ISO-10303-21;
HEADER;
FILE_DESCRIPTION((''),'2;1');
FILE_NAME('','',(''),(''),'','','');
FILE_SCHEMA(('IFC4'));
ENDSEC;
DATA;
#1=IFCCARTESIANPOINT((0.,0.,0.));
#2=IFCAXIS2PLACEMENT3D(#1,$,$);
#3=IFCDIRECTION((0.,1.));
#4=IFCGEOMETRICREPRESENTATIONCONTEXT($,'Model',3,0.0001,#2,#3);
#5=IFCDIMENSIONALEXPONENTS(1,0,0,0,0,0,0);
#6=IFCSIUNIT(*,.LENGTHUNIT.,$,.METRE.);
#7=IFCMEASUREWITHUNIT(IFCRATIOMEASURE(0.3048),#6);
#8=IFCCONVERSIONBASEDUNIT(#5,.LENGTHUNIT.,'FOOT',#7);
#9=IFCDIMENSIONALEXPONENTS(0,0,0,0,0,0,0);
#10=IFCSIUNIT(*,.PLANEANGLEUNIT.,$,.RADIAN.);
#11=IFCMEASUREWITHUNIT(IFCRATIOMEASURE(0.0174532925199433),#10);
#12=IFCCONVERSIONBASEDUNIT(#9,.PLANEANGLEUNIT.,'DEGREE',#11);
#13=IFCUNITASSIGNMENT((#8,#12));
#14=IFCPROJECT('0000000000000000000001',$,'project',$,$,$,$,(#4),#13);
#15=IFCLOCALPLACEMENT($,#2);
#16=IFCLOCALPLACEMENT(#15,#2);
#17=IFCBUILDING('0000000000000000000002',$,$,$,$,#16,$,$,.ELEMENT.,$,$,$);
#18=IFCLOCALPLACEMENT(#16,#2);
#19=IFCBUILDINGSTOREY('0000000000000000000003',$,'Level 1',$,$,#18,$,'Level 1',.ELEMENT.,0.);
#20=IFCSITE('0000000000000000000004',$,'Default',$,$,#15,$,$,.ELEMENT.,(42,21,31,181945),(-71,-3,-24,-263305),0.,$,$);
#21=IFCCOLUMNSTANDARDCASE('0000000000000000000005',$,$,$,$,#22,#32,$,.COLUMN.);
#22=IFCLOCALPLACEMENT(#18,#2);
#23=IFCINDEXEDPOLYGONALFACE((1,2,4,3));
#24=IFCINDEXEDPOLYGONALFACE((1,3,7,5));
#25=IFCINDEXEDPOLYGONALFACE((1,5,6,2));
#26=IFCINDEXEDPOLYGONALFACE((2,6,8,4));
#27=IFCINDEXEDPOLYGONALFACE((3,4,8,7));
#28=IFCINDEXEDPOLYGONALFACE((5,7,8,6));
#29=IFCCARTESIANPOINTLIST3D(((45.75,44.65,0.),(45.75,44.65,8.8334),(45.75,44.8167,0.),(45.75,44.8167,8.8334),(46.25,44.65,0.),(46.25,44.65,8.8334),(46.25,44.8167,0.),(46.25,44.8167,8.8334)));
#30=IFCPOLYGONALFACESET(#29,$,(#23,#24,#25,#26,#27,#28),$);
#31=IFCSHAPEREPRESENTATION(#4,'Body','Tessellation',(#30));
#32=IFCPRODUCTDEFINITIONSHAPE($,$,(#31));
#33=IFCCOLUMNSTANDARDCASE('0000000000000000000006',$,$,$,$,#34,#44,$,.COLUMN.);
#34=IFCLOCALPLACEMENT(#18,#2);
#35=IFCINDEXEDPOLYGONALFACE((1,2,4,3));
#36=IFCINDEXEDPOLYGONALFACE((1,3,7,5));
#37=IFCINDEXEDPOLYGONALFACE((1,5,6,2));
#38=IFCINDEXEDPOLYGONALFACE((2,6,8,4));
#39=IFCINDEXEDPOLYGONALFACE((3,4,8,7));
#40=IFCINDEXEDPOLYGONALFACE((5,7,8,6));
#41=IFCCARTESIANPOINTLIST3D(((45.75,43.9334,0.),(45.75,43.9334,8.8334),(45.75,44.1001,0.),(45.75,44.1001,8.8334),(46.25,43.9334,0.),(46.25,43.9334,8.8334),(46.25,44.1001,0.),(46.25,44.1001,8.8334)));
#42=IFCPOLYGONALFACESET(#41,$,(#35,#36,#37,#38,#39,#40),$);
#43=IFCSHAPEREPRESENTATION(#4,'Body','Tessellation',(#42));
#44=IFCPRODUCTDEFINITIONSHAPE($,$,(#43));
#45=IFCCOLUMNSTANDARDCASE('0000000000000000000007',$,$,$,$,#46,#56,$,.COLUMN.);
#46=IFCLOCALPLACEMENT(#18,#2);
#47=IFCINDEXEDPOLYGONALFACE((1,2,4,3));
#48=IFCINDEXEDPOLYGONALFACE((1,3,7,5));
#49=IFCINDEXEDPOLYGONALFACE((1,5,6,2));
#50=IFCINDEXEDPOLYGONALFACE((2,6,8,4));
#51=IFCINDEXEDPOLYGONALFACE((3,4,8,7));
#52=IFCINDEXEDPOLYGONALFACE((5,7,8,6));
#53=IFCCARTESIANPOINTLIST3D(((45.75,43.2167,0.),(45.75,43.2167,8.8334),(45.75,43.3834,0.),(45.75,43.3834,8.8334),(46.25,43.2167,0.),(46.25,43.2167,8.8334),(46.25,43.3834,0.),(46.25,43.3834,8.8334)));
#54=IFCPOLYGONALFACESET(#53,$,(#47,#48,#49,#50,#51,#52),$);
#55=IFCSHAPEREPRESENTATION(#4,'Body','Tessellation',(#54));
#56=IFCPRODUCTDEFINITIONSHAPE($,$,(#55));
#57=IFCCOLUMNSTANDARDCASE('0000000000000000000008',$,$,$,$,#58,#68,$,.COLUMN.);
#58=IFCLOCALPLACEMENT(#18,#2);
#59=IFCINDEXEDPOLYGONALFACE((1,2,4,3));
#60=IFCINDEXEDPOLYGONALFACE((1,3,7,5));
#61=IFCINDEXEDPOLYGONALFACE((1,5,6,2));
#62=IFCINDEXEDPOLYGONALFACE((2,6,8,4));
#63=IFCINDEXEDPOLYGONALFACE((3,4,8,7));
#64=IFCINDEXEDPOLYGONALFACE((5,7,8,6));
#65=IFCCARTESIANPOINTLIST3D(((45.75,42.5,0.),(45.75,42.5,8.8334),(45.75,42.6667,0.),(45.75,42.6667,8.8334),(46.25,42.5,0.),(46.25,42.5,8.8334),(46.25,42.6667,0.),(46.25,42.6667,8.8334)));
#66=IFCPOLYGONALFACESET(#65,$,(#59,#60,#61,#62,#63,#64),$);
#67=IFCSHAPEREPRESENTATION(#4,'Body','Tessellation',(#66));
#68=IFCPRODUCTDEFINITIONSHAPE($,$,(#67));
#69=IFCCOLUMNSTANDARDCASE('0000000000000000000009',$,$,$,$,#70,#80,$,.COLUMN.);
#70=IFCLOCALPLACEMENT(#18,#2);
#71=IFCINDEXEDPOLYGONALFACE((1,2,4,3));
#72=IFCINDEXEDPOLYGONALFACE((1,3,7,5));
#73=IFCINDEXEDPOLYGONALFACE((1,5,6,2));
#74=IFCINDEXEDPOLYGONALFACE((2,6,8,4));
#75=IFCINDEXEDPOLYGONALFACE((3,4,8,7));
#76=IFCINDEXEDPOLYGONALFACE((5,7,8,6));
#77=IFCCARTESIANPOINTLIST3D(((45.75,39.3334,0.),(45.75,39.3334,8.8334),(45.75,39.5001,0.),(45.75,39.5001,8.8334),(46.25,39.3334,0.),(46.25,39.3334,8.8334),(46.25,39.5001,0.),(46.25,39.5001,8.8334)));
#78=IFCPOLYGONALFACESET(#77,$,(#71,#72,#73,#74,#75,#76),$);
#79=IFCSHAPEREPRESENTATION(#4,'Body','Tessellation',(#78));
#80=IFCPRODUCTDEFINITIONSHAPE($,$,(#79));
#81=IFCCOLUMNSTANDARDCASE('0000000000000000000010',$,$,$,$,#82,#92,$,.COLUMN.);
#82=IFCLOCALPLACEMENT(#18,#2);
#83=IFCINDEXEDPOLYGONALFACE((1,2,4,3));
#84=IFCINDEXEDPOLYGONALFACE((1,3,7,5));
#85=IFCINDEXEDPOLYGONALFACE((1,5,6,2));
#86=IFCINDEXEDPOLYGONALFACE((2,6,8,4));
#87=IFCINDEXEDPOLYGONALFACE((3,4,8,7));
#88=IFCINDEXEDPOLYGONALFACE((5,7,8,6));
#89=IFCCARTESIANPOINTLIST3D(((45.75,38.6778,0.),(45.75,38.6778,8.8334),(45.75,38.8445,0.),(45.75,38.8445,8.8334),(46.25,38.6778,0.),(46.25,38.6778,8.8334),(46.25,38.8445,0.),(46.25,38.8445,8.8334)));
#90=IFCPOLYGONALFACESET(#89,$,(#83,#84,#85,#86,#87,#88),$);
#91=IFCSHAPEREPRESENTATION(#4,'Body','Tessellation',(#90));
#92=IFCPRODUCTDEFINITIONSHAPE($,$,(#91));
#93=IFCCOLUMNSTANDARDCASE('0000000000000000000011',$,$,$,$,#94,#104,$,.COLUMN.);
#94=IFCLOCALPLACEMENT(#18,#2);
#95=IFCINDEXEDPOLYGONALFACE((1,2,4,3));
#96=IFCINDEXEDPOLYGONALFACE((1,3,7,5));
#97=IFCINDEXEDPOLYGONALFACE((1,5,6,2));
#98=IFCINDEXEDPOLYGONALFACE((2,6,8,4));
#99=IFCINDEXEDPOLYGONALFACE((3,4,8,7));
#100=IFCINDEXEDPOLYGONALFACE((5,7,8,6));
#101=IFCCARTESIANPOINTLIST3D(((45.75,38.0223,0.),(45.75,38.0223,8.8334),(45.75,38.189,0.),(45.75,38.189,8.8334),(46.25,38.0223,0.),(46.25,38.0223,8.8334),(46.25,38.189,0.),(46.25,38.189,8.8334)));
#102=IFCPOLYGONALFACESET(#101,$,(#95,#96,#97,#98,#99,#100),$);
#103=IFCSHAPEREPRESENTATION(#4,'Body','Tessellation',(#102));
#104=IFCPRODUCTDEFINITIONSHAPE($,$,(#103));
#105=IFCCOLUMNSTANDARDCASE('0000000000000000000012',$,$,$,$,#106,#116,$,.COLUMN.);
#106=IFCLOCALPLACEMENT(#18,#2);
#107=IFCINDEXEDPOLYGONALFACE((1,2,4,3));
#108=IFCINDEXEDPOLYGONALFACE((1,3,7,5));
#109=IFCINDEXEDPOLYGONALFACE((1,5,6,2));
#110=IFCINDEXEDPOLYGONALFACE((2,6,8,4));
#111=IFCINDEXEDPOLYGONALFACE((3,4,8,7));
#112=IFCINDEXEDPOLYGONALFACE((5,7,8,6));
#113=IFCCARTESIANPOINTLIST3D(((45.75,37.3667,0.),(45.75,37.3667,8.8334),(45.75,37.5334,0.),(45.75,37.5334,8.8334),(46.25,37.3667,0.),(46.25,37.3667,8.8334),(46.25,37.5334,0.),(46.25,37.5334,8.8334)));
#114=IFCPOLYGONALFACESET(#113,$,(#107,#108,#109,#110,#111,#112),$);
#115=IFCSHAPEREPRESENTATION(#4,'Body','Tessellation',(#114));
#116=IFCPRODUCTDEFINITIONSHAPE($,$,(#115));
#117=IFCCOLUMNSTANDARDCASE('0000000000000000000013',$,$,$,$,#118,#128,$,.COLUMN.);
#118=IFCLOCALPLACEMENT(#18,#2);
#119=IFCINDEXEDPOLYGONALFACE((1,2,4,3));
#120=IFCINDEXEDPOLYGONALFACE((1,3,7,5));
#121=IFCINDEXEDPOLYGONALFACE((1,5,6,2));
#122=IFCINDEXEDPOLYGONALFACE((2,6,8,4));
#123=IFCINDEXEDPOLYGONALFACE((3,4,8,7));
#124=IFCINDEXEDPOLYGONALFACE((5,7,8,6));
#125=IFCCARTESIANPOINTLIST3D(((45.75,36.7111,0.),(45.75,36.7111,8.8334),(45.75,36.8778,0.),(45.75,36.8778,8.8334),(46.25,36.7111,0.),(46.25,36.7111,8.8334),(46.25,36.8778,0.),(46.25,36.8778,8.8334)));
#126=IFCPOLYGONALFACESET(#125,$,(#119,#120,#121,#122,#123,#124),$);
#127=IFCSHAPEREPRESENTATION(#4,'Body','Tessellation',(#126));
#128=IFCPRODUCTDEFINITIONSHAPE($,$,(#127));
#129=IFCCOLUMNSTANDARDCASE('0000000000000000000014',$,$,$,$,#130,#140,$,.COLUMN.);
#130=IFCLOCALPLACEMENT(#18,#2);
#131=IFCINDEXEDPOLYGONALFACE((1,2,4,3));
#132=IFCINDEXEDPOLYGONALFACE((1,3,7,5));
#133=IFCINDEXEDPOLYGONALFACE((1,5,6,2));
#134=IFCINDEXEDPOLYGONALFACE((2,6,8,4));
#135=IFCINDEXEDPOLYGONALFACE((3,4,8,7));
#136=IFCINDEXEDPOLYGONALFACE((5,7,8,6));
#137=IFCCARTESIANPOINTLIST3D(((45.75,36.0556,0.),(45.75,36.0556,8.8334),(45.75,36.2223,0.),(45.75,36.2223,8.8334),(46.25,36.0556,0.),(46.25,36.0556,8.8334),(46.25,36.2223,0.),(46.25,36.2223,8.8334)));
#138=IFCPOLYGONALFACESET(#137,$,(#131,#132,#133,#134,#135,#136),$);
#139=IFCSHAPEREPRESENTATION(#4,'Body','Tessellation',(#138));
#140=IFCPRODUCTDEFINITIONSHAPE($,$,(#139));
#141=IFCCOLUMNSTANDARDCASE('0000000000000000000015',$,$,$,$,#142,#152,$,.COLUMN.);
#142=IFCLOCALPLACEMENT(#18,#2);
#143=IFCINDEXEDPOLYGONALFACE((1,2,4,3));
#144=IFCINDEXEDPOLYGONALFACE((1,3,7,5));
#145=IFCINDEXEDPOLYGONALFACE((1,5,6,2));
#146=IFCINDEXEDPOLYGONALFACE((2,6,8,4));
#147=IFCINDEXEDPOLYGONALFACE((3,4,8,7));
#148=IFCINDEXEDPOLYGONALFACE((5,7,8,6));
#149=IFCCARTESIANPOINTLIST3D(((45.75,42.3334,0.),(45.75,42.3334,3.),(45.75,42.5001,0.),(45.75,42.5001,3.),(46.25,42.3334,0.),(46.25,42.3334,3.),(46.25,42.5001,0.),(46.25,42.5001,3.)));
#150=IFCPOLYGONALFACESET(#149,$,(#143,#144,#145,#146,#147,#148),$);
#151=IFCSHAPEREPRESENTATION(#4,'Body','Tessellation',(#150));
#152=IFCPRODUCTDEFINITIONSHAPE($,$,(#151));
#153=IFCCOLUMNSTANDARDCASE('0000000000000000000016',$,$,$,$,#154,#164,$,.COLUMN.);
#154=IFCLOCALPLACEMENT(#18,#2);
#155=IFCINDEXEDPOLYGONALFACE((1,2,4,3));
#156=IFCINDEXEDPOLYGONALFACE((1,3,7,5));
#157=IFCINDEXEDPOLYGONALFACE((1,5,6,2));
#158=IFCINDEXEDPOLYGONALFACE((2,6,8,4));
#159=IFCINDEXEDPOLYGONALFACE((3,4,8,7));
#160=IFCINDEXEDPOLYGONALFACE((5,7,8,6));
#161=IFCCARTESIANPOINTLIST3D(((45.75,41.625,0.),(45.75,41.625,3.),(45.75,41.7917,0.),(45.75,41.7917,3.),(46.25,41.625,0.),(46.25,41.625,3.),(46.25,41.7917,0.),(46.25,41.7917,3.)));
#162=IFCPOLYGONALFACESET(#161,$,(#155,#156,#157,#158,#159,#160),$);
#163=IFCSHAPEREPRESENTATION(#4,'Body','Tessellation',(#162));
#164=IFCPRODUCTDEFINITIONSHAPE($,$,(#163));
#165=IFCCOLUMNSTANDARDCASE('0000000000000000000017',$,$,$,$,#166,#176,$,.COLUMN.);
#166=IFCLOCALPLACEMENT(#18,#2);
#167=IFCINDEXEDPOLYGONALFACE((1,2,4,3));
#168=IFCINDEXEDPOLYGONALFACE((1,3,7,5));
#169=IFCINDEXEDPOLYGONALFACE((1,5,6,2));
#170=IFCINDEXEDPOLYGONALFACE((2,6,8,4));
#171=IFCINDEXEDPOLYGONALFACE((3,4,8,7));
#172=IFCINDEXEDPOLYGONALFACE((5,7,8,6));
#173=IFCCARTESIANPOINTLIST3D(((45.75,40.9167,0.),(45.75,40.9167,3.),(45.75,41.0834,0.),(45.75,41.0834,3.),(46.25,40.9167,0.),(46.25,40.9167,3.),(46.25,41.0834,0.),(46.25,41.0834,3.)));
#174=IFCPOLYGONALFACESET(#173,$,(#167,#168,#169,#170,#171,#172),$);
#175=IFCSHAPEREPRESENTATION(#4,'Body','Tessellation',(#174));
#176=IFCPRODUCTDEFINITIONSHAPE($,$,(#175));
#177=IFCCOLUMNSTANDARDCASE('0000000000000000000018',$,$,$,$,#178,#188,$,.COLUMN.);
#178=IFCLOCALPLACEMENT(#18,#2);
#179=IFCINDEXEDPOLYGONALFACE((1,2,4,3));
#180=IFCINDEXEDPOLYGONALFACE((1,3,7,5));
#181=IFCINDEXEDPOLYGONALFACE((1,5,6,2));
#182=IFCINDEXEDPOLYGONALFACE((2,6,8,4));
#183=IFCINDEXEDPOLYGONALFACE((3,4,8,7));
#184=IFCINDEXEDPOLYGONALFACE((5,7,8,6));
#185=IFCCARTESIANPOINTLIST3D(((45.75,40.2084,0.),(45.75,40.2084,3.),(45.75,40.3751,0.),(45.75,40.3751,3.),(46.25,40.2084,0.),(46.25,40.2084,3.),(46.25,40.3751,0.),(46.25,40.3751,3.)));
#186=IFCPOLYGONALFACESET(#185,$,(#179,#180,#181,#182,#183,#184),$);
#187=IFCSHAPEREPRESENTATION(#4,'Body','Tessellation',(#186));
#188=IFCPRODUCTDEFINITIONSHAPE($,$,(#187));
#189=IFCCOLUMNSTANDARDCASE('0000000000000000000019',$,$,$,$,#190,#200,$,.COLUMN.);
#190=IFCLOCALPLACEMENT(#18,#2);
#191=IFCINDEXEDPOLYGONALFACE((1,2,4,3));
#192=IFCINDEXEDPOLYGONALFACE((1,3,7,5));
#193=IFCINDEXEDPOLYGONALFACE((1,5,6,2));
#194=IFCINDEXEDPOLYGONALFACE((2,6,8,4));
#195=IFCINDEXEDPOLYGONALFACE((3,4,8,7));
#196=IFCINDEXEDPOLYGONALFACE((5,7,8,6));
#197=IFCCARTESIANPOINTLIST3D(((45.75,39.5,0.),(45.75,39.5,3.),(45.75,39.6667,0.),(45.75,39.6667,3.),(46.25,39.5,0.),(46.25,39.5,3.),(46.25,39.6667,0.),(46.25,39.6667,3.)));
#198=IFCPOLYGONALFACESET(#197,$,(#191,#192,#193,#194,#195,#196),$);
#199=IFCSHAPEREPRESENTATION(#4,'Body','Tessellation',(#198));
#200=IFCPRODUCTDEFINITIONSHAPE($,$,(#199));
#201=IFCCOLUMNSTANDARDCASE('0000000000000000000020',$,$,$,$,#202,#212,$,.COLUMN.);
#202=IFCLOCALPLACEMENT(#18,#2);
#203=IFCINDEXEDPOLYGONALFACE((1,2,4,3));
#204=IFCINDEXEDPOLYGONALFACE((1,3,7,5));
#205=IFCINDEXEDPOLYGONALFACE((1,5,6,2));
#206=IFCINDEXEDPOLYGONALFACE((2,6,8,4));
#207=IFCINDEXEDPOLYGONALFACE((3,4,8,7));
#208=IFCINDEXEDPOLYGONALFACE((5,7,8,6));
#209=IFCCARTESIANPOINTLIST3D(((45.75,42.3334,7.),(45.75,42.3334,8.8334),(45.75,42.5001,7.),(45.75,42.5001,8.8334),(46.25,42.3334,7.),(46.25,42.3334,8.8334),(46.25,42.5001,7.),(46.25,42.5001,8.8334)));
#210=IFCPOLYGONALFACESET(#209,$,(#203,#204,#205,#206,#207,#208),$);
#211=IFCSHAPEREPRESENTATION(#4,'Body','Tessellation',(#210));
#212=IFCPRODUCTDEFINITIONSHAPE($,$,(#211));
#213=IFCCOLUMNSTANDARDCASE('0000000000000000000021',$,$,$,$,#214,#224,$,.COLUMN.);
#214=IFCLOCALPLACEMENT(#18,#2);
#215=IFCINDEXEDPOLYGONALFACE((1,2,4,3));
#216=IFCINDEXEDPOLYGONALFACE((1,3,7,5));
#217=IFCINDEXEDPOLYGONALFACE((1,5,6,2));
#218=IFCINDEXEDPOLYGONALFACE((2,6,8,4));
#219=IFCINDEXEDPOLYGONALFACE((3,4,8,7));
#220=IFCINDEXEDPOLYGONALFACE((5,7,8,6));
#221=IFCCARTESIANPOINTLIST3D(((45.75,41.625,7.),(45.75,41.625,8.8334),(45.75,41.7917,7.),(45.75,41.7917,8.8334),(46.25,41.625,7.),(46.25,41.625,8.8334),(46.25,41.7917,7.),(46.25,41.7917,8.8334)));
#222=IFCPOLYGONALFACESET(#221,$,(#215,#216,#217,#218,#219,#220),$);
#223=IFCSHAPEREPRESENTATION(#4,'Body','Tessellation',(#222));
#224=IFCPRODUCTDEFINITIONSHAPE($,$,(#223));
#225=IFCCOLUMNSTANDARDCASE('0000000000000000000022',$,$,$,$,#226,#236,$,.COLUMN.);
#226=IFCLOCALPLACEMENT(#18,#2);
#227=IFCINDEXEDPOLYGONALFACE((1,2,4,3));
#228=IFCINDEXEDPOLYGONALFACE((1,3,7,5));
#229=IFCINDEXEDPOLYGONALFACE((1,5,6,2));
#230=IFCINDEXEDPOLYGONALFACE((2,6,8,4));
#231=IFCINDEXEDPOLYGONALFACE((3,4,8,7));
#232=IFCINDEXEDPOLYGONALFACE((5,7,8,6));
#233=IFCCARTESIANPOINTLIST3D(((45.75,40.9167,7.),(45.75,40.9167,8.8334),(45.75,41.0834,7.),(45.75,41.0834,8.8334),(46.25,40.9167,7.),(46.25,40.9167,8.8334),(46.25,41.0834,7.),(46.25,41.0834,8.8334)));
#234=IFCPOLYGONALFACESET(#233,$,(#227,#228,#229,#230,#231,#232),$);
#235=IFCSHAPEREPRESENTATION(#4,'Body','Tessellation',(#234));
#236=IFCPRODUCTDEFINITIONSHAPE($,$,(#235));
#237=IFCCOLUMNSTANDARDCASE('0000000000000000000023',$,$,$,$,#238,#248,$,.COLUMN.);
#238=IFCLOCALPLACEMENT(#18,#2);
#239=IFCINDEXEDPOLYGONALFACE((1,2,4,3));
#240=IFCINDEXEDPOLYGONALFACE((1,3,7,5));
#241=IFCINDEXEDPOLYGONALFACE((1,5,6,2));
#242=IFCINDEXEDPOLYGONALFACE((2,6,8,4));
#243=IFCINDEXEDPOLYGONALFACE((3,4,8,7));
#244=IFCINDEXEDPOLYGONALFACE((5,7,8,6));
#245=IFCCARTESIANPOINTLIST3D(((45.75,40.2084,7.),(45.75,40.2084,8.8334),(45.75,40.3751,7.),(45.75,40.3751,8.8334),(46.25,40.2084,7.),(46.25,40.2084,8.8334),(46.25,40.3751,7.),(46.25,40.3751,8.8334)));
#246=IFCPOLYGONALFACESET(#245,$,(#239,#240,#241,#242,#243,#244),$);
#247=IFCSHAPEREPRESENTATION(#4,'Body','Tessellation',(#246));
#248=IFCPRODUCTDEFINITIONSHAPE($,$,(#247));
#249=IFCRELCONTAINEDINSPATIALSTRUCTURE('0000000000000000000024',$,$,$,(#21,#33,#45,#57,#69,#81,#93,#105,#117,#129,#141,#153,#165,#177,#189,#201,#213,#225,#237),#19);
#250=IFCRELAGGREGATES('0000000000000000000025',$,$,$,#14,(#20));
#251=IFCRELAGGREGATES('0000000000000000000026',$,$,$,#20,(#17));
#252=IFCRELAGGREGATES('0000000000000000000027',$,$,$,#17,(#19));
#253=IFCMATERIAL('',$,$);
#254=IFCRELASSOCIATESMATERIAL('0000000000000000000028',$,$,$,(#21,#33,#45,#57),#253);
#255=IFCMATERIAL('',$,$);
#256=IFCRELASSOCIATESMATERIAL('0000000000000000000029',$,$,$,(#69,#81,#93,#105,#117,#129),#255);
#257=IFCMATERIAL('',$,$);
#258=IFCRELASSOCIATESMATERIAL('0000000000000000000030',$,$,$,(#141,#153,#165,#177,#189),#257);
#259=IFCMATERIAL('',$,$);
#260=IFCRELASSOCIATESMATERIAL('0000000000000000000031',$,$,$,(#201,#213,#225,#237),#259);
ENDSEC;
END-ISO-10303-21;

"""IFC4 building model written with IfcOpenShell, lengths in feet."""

from ifc_helpers import new_model, entity, si_unit, converted_unit, direction, frame, origin, place, context, project, spatial, rectangle, extrude, material, element, save


model = new_model("IFC4")

# Units and contexts
model_context = context("Model", 3, precision=0.0001, world=origin(), true_north=direction((0.0, 1.0)))
ifc_project = project(units=[converted_unit("LENGTHUNIT", "FOOT", entity("IfcRatioMeasure", 0.3048), si_unit("LENGTHUNIT", "METRE"), dimensions=[1, 0, 0, 0, 0, 0, 0]), converted_unit("PLANEANGLEUNIT", "DEGREE", entity("IfcRatioMeasure", 0.0174532925199433), si_unit("PLANEANGLEUNIT", "RADIAN"), dimensions=[0, 0, 0, 0, 0, 0, 0])], contexts=[model_context])

# Site, building, storey
site_placement = place(None, origin())
site = spatial("IfcSite", under=ifc_project, at=site_placement, Name="Default", CompositionType="ELEMENT", RefLatitude=(42, 21, 31, 181945), RefLongitude=(-71, -3, -24, -263305), RefElevation=0.0)
building_placement = place(site_placement, origin())
building = spatial("IfcBuilding", under=site, at=building_placement, CompositionType="ELEMENT")
storey_placement = place(building_placement, origin())
storey = spatial("IfcBuildingStorey", under=building, at=storey_placement, Name="Level 1", LongName="Level 1", CompositionType="ELEMENT", Elevation=0.0)

# Columns
ifc_material_1 = material(Name="")
placement_1 = place(storey_placement, frame((46.0, 46.25, 0.0), z_axis=(0.0, 0.0, 1.0), x_axis=(0.0, -1.0, 0.0)))
for number, where, z_axis, x_axis in (
    (1, (1.5167, 0.0, 0.0), (0.0, 0.0, 1.0), (1.0, 0.0, 0.0)),
    (2, (2.2333, 0.0, 0.0), (0.0, 0.0, 1.0), (1.0, 0.0, 0.0)),
    (3, (2.95, 0.0, 0.0), (0.0, 0.0, 1.0), (1.0, 0.0, 0.0)),
    (4, (3.6667, 0.0, 0.0), (0.0, 0.0, 1.0), (1.0, 0.0, 0.0)),
):
    element("IfcColumnStandardCase", number, at=place(placement_1, frame(where, z_axis=z_axis, x_axis=x_axis)), inside=storey, material=ifc_material_1, PredefinedType="COLUMN", context=model_context, shape_type="SweptSolid", body=[
        extrude(rectangle(XDim=0.1667, YDim=0.5), origin(), (0.0, 0.0, 1.0), 8.8334),
    ])
ifc_material_2 = material(Name="")
for number, where, z_axis, x_axis in (
    (5, (6.8333, 0.0, 0.0), (0.0, 0.0, 1.0), (1.0, 0.0, 0.0)),
    (6, (7.4889, 0.0, 0.0), (0.0, 0.0, 1.0), (1.0, 0.0, 0.0)),
    (7, (8.1444, 0.0, 0.0), (0.0, 0.0, 1.0), (1.0, 0.0, 0.0)),
    (8, (8.8, 0.0, 0.0), (0.0, 0.0, 1.0), (1.0, 0.0, 0.0)),
    (9, (9.4556, 0.0, 0.0), (0.0, 0.0, 1.0), (1.0, 0.0, 0.0)),
    (10, (10.1111, 0.0, 0.0), (0.0, 0.0, 1.0), (1.0, 0.0, 0.0)),
):
    element("IfcColumnStandardCase", number, at=place(placement_1, frame(where, z_axis=z_axis, x_axis=x_axis)), inside=storey, material=ifc_material_2, PredefinedType="COLUMN", context=model_context, shape_type="SweptSolid", body=[
        extrude(rectangle(XDim=0.1667, YDim=0.5), origin(), (0.0, 0.0, 1.0), 8.8334),
    ])
ifc_material_3 = material(Name="")
for number, where, z_axis, x_axis in (
    (11, (3.8333, 0.0, 0.0), (0.0, 0.0, 1.0), (1.0, 0.0, 0.0)),
    (12, (4.5417, 0.0, 0.0), (0.0, 0.0, 1.0), (1.0, 0.0, 0.0)),
    (13, (5.25, 0.0, 0.0), (0.0, 0.0, 1.0), (1.0, 0.0, 0.0)),
    (14, (5.9583, 0.0, 0.0), (0.0, 0.0, 1.0), (1.0, 0.0, 0.0)),
    (15, (6.6667, 0.0, 0.0), (0.0, 0.0, 1.0), (1.0, 0.0, 0.0)),
):
    element("IfcColumnStandardCase", number, at=place(placement_1, frame(where, z_axis=z_axis, x_axis=x_axis)), inside=storey, material=ifc_material_3, PredefinedType="COLUMN", context=model_context, shape_type="SweptSolid", body=[
        extrude(rectangle(XDim=0.1667, YDim=0.5), origin(), (0.0, 0.0, 1.0), 3.0),
    ])
ifc_material_4 = material(Name="")
for number, where, z_axis, x_axis in (
    (16, (3.8333, 0.0, 7.0), (0.0, 0.0, 1.0), (1.0, 0.0, 0.0)),
    (17, (4.5417, 0.0, 7.0), (0.0, 0.0, 1.0), (1.0, 0.0, 0.0)),
    (18, (5.25, 0.0, 7.0), (0.0, 0.0, 1.0), (1.0, 0.0, 0.0)),
    (19, (5.9583, 0.0, 7.0), (0.0, 0.0, 1.0), (1.0, 0.0, 0.0)),
):
    element("IfcColumnStandardCase", number, at=place(placement_1, frame(where, z_axis=z_axis, x_axis=x_axis)), inside=storey, material=ifc_material_4, PredefinedType="COLUMN", context=model_context, shape_type="SweptSolid", body=[
        extrude(rectangle(XDim=0.1667, YDim=0.5), origin(), (0.0, 0.0, 1.0), 1.8334),
    ])

save(model, "model.ifc")
